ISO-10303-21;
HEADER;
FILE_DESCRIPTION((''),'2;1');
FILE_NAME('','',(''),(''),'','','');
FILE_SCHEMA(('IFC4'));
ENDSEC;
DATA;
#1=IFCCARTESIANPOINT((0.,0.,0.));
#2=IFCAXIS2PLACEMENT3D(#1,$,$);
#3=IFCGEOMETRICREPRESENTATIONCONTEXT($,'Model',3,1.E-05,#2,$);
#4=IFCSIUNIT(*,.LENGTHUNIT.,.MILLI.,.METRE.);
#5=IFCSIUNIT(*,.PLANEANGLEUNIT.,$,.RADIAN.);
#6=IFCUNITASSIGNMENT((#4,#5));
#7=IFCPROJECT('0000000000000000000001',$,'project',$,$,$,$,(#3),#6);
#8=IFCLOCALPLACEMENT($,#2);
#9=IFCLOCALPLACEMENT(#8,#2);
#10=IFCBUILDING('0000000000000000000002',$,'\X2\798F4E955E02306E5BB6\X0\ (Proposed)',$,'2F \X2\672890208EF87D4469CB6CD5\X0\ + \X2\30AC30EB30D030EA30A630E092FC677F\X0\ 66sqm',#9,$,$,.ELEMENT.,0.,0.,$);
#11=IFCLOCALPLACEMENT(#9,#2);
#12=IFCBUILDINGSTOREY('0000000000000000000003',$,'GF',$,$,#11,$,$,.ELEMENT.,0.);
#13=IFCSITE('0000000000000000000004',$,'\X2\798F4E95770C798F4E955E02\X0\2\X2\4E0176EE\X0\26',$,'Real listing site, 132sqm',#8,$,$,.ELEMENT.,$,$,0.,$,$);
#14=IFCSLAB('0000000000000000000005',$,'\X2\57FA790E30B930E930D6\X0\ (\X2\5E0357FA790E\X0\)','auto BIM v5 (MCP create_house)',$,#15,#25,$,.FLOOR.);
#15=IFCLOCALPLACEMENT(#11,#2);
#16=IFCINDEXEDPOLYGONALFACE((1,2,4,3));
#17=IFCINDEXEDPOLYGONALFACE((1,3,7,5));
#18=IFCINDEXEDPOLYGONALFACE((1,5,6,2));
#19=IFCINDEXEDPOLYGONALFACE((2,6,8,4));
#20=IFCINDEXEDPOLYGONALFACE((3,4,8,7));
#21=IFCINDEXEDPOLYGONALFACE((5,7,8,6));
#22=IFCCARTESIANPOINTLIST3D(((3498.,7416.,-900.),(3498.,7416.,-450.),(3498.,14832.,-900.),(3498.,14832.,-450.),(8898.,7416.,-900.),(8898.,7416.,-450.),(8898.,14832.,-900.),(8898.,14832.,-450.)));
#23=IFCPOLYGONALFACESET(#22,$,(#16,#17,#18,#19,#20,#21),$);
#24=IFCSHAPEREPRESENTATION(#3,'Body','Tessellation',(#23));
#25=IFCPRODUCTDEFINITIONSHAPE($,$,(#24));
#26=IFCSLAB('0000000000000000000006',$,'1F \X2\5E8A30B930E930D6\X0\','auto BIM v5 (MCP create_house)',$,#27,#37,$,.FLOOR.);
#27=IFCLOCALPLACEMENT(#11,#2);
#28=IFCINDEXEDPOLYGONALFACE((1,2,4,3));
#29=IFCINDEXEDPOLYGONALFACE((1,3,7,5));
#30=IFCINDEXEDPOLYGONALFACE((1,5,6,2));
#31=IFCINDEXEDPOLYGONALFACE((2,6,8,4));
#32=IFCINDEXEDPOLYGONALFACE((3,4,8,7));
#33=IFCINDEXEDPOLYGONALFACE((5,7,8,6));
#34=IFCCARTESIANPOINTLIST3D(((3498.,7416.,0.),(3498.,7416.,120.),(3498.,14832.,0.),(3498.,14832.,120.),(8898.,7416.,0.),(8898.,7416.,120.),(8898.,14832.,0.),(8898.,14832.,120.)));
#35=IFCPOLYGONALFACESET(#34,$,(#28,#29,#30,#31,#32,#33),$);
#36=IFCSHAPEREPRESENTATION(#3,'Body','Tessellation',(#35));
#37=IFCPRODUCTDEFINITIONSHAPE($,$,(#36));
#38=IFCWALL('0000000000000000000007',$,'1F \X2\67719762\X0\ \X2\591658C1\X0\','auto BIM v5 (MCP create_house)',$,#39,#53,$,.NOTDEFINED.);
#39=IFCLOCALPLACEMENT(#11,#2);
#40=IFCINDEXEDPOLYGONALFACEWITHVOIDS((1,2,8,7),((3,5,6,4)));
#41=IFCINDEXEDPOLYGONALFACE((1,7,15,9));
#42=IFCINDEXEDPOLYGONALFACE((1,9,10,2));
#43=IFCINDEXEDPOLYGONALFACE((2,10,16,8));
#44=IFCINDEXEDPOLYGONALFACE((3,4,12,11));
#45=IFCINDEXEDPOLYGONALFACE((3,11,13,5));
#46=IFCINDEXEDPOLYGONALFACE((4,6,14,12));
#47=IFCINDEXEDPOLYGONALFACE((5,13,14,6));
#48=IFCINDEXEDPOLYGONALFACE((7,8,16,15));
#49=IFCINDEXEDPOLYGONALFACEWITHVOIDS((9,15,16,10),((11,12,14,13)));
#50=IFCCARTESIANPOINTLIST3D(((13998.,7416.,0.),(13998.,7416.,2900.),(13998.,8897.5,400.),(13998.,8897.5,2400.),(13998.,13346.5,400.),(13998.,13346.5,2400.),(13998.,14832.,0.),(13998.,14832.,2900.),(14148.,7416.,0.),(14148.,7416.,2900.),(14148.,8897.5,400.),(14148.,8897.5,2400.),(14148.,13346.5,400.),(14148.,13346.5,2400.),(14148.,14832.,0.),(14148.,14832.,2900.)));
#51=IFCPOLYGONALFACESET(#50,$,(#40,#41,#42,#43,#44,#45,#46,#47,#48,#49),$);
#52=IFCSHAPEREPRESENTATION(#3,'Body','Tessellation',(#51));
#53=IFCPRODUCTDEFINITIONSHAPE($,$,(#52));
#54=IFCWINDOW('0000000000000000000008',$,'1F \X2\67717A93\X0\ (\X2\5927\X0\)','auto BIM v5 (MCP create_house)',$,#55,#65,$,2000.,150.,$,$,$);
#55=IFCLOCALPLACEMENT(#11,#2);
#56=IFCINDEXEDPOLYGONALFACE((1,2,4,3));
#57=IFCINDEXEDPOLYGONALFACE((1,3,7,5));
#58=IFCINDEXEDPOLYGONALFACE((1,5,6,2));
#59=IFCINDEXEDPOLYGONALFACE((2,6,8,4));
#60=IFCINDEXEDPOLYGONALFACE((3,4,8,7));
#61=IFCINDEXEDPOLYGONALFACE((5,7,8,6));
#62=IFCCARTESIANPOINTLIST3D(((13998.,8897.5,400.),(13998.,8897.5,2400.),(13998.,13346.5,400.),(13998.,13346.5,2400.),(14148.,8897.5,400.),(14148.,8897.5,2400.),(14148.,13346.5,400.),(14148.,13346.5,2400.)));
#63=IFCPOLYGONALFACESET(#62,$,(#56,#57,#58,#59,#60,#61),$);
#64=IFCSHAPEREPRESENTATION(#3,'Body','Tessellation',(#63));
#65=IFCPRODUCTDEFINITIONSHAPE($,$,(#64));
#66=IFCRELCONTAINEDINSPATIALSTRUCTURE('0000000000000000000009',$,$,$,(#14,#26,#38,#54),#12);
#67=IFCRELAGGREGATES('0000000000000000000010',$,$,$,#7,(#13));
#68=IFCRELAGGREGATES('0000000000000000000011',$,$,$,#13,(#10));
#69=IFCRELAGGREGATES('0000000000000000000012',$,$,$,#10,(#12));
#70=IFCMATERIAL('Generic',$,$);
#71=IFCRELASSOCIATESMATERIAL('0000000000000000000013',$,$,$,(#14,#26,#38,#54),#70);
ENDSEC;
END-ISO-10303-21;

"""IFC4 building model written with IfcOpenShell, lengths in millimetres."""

from ifc_helpers import new_model, si_unit, frame, frame_2d, origin, place, context, project, spatial, rectangle, extrude, material, element, fill, save


model = new_model("IFC4")

# Units and contexts
model_context = context("Model", 3, precision=1e-05, world=origin())
ifc_project = project(units=[si_unit("LENGTHUNIT", "METRE", prefix="MILLI"), si_unit("PLANEANGLEUNIT", "RADIAN")], contexts=[model_context])

# Site, building, storey
site_placement = place(None, origin())
site = spatial("IfcSite", under=ifc_project, at=site_placement, Name="福井県福井市2丁目26", ObjectType="Real listing site, 132sqm", CompositionType="ELEMENT", RefElevation=0.0)
building_placement = place(site_placement, origin())
building = spatial("IfcBuilding", under=site, at=building_placement, Name="福井市の家 (Proposed)", ObjectType="2F 木造軸組構法 + ガルバリウム鋼板 66sqm", CompositionType="ELEMENT", ElevationOfRefHeight=0.0, ElevationOfTerrain=0.0)
storey_placement = place(building_placement, origin())
storey = spatial("IfcBuildingStorey", under=building, at=storey_placement, Name="GF", CompositionType="ELEMENT", Elevation=0.0)

# Slabs
ifc_material = material(Name="Generic")
slab_1_placement = place(storey_placement, frame((1749.0, 3708.0, -450.0)))
element("IfcSlab", 1, at=slab_1_placement, inside=storey, material=ifc_material, Name="基礎スラブ (布基礎)", Description="auto BIM v5 (MCP create_house)", PredefinedType="FLOOR", context=model_context, shape_type="SweptSolid", body=[
    extrude(rectangle(XDim=5400.0, YDim=7416.0, at=frame_2d((2700.0, 3708.0))), frame((1749.0, 3708.0, -450.0)), (0.0, 0.0, 1.0), 450.0),
])
slab_2_placement = place(storey_placement, frame((1749.0, 3708.0, 0.0)))
element("IfcSlab", 2, at=slab_2_placement, inside=storey, material=ifc_material, Name="1F 床スラブ", Description="auto BIM v5 (MCP create_house)", PredefinedType="FLOOR", context=model_context, shape_type="SweptSolid", body=[
    extrude(rectangle(XDim=5400.0, YDim=7416.0, at=frame_2d((2700.0, 3708.0))), frame((1749.0, 3708.0, 0.0)), (0.0, 0.0, 1.0), 120.0),
])

# Wall, opening, window
wall_1_placement = place(storey_placement, frame((6999.0, 3708.0, 0.0)))
wall_1 = element("IfcWall", 3, at=wall_1_placement, inside=storey, material=ifc_material, Name="1F 東面 外壁", Description="auto BIM v5 (MCP create_house)", PredefinedType="NOTDEFINED", context=model_context, shape_type="SweptSolid", body=[
    extrude(rectangle(XDim=150.0, YDim=7416.0, at=frame_2d((75.0, 3708.0))), frame((6999.0, 3708.0, 0.0)), (0.0, 0.0, 1.0), 2900.0),
])
opening_1_placement = place(storey_placement, frame((6999.0, 4449.0, 200.0)))
opening_1 = element("IfcOpeningElement", 4, at=opening_1_placement, cuts=wall_1, PredefinedType="NOTDEFINED", context=model_context, shape_type="SweptSolid", body=[
    extrude(rectangle(XDim=150.0, YDim=4449.0, at=frame_2d((75.0, 2224.0))), frame((6999.0, 4449.0, 200.0)), (0.0, 0.0, 1.0), 2000.0),
])
window_1_placement = place(storey_placement, frame((6999.0, 4449.0, 200.0)))
window_1 = element("IfcWindow", 5, at=window_1_placement, inside=storey, material=ifc_material, Name="1F 東窓 (大)", Description="auto BIM v5 (MCP create_house)", OverallHeight=2000.0, OverallWidth=150.0, context=model_context, shape_type="SweptSolid", body=[
    extrude(rectangle(XDim=150.0, YDim=4449.0, at=frame_2d((75.0, 2224.0))), frame((6999.0, 4449.0, 200.0)), (0.0, 0.0, 1.0), 2000.0),
])
fill(opening_1, window_1)

save(model, "model.ifc")
